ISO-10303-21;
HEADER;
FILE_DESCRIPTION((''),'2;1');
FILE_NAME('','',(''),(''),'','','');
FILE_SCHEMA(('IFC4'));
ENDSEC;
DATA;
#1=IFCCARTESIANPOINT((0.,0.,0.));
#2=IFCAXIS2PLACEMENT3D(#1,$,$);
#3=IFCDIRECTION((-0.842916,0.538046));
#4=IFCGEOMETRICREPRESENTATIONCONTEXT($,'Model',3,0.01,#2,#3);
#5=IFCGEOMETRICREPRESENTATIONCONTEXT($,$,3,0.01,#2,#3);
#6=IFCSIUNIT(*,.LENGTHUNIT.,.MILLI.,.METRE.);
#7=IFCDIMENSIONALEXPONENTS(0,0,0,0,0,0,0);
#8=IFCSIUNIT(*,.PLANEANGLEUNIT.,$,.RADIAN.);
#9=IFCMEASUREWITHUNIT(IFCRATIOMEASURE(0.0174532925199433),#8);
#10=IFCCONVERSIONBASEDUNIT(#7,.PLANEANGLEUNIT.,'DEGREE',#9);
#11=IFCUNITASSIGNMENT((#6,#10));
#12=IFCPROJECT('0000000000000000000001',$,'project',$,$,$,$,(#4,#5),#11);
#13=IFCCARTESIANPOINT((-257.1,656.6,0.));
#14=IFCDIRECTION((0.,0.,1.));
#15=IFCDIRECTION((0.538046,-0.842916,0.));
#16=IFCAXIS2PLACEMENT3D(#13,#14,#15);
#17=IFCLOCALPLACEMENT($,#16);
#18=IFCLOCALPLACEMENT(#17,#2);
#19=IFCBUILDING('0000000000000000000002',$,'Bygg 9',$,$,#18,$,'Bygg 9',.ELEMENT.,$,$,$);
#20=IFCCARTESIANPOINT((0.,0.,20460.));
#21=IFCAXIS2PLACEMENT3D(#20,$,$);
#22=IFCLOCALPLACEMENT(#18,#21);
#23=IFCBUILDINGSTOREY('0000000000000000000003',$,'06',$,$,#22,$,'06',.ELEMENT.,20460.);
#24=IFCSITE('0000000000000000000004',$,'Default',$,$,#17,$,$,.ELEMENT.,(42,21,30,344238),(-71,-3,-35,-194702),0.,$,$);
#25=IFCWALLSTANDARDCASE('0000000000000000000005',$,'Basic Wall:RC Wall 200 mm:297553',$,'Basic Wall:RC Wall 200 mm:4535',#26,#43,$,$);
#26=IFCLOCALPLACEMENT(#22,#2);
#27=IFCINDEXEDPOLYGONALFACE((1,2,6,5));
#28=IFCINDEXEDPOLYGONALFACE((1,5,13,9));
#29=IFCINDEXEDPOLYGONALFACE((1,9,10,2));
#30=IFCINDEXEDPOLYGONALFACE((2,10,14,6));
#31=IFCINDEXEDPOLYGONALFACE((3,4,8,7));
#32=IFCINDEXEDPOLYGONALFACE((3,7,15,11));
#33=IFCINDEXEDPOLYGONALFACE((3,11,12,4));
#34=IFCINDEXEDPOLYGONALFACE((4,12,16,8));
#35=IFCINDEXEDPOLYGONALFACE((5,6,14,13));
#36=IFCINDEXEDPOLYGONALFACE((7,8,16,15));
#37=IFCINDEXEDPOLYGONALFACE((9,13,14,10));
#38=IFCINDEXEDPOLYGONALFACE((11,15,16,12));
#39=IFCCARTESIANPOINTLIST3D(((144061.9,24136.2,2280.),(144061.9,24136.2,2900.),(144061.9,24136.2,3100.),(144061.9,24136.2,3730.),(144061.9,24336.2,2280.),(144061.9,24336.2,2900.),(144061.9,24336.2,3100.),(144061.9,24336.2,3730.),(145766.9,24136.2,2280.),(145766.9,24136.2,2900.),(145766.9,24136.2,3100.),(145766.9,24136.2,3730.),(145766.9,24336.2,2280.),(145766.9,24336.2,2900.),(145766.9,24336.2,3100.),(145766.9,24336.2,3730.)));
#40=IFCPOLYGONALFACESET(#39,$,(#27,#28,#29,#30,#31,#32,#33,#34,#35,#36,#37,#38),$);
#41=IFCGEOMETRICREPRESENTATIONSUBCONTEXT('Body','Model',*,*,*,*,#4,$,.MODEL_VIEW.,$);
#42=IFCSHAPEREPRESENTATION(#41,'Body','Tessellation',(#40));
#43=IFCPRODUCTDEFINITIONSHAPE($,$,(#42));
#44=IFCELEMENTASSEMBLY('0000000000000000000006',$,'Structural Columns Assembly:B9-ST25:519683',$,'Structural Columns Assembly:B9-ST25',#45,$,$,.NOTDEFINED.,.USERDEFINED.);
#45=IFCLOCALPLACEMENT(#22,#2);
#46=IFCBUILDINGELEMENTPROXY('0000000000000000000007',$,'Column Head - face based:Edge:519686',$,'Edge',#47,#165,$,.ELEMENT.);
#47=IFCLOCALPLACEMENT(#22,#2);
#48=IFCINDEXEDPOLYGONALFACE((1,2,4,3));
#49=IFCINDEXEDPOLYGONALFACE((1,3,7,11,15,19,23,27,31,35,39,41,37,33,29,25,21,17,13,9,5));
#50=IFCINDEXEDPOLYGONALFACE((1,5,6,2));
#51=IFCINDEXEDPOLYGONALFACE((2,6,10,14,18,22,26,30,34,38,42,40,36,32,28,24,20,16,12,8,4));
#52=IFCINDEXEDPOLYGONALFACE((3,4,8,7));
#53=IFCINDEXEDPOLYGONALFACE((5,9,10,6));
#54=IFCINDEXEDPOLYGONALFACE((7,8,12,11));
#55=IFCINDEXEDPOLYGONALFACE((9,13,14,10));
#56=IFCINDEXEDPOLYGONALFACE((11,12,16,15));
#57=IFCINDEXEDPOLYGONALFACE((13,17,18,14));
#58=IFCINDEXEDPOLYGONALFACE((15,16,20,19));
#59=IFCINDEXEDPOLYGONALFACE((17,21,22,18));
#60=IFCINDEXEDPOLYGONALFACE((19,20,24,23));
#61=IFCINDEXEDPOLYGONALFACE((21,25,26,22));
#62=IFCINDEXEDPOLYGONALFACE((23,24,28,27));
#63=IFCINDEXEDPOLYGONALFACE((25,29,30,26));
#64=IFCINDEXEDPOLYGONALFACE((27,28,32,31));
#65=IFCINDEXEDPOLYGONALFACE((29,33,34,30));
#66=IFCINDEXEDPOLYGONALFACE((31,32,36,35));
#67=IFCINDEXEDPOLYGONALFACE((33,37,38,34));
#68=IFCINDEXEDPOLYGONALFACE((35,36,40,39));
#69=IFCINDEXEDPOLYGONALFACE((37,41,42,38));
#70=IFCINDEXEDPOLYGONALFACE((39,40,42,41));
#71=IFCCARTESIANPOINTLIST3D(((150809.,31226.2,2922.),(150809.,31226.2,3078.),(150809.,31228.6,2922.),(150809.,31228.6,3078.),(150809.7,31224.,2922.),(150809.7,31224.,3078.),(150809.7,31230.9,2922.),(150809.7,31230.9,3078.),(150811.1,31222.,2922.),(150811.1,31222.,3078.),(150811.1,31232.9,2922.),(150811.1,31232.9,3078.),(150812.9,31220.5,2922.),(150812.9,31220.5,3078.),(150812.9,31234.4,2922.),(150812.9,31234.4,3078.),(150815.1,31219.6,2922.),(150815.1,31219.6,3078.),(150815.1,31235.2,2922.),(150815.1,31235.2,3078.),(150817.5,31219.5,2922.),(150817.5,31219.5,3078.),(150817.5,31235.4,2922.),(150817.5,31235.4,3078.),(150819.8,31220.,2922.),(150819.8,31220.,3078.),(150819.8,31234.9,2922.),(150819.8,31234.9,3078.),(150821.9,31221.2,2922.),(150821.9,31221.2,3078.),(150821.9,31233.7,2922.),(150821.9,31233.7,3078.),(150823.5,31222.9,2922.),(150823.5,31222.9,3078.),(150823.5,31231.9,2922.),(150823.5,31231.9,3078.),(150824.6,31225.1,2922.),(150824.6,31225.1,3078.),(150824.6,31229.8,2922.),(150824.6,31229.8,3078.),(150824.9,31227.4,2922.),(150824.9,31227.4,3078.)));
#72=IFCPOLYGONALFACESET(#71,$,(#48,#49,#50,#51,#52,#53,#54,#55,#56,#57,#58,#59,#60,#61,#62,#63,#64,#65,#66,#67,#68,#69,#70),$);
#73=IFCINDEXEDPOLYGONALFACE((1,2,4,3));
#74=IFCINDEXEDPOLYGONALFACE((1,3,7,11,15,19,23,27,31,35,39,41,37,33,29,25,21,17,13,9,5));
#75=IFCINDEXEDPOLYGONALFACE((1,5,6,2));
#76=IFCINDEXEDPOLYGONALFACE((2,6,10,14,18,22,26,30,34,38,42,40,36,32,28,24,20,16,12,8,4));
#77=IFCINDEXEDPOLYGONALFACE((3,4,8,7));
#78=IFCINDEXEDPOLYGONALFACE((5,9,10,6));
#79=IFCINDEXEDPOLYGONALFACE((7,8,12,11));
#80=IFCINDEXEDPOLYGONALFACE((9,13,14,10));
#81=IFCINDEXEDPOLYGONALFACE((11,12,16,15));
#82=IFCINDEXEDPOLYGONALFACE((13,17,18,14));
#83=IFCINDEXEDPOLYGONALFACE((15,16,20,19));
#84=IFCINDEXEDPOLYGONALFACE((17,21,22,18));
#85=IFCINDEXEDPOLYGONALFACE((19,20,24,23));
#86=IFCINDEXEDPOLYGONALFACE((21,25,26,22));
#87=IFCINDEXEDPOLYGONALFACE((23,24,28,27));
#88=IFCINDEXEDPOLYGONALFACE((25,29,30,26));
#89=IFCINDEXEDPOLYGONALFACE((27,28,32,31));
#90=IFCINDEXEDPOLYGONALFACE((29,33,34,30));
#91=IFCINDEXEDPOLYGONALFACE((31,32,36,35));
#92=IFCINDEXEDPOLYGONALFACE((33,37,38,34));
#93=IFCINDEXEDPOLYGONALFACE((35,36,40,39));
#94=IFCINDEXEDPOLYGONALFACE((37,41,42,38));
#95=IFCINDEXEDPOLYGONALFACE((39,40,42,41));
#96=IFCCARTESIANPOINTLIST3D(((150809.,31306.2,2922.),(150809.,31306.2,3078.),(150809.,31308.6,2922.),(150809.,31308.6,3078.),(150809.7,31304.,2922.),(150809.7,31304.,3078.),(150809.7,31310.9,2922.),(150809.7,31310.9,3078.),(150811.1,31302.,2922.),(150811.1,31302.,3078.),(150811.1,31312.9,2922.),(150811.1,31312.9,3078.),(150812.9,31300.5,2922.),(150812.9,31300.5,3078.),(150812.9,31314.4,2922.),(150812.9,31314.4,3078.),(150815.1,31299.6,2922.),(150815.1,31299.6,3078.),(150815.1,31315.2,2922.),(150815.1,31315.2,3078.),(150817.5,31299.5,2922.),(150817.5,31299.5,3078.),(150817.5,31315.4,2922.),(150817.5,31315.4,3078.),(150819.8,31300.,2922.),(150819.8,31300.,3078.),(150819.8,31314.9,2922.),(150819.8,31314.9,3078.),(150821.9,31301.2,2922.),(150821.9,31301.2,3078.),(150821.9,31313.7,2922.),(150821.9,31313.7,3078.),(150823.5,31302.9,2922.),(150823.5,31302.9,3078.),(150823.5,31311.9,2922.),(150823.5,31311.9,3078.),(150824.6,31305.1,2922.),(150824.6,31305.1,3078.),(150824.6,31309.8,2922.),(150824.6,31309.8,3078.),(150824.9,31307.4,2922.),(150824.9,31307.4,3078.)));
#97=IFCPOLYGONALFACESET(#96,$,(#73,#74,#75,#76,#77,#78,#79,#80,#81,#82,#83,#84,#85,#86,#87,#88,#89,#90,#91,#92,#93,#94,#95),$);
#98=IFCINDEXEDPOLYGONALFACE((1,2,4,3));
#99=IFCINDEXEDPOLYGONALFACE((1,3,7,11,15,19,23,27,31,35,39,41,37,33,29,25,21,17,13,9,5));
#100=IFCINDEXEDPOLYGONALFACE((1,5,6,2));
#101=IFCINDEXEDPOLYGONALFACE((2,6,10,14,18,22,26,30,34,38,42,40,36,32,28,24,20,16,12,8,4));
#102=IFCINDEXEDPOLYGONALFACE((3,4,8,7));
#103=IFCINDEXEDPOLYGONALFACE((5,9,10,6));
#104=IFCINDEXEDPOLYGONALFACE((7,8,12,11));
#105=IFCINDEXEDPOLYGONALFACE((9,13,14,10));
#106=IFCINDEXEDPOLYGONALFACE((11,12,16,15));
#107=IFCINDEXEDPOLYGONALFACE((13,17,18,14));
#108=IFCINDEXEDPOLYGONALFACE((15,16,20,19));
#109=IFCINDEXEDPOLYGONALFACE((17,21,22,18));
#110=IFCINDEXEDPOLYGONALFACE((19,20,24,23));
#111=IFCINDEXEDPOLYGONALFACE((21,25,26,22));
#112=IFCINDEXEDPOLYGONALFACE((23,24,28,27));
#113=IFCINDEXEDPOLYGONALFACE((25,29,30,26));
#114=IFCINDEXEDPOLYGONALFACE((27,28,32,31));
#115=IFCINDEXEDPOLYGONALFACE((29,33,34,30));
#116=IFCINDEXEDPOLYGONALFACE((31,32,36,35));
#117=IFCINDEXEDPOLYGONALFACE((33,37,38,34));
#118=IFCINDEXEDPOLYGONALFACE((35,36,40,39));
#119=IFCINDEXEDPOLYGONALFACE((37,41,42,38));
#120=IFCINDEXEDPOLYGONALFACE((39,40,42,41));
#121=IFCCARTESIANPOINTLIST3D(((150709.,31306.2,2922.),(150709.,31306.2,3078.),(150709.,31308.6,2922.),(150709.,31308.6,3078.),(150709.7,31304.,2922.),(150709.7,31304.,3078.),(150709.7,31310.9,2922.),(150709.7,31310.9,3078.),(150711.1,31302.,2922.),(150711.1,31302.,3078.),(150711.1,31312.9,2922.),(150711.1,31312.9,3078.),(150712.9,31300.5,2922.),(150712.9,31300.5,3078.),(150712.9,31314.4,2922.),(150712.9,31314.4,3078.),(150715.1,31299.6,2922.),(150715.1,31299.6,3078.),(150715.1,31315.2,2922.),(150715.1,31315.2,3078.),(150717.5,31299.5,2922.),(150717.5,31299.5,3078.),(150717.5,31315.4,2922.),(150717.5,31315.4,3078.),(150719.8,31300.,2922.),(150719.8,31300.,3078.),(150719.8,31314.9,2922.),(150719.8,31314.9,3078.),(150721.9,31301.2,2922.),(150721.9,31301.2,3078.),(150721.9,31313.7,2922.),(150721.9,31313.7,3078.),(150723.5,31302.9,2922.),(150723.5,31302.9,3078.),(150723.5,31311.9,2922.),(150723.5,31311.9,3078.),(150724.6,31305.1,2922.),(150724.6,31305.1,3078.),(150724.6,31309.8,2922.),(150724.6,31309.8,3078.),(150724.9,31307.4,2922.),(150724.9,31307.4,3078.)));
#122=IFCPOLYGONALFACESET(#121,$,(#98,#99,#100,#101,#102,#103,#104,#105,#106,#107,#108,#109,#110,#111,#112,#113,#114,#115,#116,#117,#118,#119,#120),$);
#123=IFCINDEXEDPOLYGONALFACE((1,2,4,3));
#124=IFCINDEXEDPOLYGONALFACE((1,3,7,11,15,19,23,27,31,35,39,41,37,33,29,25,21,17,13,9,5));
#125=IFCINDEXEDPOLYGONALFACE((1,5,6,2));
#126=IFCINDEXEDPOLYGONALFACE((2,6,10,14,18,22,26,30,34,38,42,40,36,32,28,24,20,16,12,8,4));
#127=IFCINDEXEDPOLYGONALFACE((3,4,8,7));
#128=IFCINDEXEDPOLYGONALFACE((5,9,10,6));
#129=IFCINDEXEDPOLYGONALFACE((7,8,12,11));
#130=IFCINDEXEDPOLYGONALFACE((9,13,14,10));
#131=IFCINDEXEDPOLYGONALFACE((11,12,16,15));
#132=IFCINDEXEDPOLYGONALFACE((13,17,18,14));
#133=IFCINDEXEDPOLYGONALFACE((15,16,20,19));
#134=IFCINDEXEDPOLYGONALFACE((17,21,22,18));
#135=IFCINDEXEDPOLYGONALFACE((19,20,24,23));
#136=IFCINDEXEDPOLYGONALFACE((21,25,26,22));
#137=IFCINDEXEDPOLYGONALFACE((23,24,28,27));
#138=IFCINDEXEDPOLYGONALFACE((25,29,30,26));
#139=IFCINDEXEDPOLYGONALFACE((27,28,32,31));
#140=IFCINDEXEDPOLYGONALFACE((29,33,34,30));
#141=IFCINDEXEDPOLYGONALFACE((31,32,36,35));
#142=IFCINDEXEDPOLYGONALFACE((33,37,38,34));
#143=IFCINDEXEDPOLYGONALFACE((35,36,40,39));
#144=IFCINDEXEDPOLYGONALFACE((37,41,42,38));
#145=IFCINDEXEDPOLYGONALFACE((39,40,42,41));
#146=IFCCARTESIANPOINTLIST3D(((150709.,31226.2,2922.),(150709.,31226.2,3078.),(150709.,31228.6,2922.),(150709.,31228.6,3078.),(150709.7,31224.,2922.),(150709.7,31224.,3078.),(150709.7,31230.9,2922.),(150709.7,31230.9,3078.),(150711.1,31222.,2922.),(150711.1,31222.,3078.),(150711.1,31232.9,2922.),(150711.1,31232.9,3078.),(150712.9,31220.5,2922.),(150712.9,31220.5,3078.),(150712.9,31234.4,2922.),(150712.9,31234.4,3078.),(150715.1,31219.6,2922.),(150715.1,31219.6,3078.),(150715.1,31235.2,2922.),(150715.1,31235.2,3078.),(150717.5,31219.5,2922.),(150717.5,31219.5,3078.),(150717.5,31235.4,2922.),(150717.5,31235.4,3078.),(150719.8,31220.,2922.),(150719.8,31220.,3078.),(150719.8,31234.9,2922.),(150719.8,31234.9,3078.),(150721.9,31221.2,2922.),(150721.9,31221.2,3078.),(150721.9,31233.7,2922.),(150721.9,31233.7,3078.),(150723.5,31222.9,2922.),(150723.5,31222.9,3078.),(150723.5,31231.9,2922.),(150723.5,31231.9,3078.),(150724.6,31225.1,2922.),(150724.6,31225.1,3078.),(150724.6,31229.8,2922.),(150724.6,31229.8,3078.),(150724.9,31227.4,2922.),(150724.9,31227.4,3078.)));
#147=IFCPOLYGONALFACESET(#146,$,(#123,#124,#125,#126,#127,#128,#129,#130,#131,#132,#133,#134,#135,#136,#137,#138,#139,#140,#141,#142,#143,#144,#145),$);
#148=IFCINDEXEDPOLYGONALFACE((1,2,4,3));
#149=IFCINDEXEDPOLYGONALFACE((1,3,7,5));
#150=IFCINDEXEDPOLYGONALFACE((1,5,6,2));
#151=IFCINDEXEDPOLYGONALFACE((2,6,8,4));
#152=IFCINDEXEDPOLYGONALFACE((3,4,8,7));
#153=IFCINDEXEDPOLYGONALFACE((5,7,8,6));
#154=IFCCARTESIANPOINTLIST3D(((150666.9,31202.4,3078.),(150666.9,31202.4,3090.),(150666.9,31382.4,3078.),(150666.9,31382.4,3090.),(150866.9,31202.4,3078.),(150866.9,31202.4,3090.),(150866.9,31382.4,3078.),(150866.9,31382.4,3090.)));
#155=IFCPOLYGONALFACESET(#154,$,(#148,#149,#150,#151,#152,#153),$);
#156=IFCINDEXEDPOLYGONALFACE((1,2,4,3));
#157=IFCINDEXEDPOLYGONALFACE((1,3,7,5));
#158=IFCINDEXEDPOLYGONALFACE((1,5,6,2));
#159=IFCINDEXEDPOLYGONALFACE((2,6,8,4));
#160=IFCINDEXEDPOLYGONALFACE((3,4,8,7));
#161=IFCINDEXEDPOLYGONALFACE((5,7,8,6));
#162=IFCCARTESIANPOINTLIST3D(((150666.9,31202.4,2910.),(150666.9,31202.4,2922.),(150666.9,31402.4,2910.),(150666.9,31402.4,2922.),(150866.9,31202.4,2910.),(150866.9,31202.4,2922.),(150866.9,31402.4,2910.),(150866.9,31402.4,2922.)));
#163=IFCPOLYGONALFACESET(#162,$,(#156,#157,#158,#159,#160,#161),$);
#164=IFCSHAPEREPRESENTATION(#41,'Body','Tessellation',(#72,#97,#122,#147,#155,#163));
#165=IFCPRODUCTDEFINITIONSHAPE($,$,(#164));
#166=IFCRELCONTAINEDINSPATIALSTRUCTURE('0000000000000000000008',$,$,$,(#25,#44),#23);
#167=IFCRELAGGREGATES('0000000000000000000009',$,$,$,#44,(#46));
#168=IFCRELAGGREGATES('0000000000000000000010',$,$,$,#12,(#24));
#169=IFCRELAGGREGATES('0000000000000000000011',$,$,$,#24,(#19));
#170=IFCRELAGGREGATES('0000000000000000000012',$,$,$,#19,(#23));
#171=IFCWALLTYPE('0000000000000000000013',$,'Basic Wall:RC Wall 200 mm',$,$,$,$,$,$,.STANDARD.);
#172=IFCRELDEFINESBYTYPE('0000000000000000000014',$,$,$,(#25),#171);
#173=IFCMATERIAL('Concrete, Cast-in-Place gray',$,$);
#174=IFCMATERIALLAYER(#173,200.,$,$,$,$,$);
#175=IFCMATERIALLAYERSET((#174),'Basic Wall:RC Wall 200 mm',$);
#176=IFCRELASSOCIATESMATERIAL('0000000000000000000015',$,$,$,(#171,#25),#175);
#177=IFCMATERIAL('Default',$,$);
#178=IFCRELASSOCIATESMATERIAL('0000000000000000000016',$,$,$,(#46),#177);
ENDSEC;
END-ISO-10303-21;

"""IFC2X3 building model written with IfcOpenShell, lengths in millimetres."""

from ifc_helpers import new_model, entity, si_unit, converted_unit, direction, frame, frame_2d, origin, origin_2d_with_axis, place, context, subcontext, project, spatial, polyline, rectangle, circle, extrude, clip, bounded_halfspace, source, transform, mapped, material, layer, layer_set, layer_usage, type_object, element, aggregate, save


model = new_model("IFC2X3")

# Units and contexts
model_context = context("Model", 3, precision=0.01, world=origin(), true_north=direction((-0.842916, 0.538046)))
context_of_model = context(None, 3, precision=0.01, world=origin(), true_north=direction((-0.842916, 0.538046)))
body_context = subcontext(model_context, "Body", "Model", "MODEL_VIEW")
ifc_project = project(units=[si_unit("LENGTHUNIT", "METRE", prefix="MILLI"), converted_unit("PLANEANGLEUNIT", "DEGREE", entity("IfcRatioMeasure", 0.0174532925199433), si_unit("PLANEANGLEUNIT", "RADIAN"), dimensions=[0, 0, 0, 0, 0, 0, 0])], contexts=[model_context, context_of_model])

# Site, building, storey
site_placement = place(None, frame((-257.1, 656.6, 0.0), z_axis=(0.0, 0.0, 1.0), x_axis=(0.538046, -0.842916, 0.0)))
site = spatial("IfcSite", under=ifc_project, at=site_placement, Name="Default", CompositionType="ELEMENT", RefLatitude=(42, 21, 30, 344238), RefLongitude=(-71, -3, -35, -194702), RefElevation=0.0)
building_placement = place(site_placement, origin())
building = spatial("IfcBuilding", under=site, at=building_placement, Name="Bygg 9", LongName="Bygg 9", CompositionType="ELEMENT")
storey_placement = place(building_placement, frame((0.0, 0.0, 20460.0)))
storey = spatial("IfcBuildingStorey", under=building, at=storey_placement, Name="06", LongName="06", CompositionType="ELEMENT", Elevation=20460.0)

# Shared definitions
ifc_material_1 = material(Name="Concrete, Cast-in-Place gray")

# Shared definitions
ifc_layer_1 = layer(ifc_material_1, 200.0)
ifc_layer_set_1 = layer_set([ifc_layer_1], Name="Basic Wall:RC Wall 200 mm")
wall_type = type_object("IfcWallType", Name="Basic Wall:RC Wall 200 mm", PredefinedType="STANDARD", material=ifc_layer_set_1)

# Wall, opening
ifc_layer_usage_1 = layer_usage(ifc_layer_set_1, "AXIS2", "NEGATIVE", 100.0)
wall_1_placement = place(storey_placement, frame((145766.9, 24236.2, 2280.0), z_axis=(0.0, 0.0, 1.0), x_axis=(-1.0, 0.0, 0.0)))
wall_1 = element("IfcWallStandardCase", 1, at=wall_1_placement, inside=storey, type_object=wall_type, material=ifc_layer_usage_1, Name="Basic Wall:RC Wall 200 mm:297553", ObjectType="Basic Wall:RC Wall 200 mm:4535", context=body_context, shape_type="Clipping", body=[
    clip(extrude(rectangle(XDim=1705.0, YDim=200.0, at=frame_2d((852.5, 0.0), x_axis=(-1.0, 0.0))), origin(), (0.0, 0.0, 1.0), 1450.0), bounded_halfspace(frame((0.0, -100.0, 1450.0), z_axis=(0.0, 0.0, -1.0), x_axis=(0.0, 1.0, 0.0)), True, frame((0.0, -100.0, 1450.0)), polyline([(0.0, 0.0), (1705.0, 0.0), (1705.0, 200.0), (978.6, 200.0), (825.7, 200.0), (0.0, 200.0), (0.0, 0.0)]))),
])
opening_placement = place(storey_placement, frame((145766.9, 24236.2, 2280.0), z_axis=(0.0, 0.0, 1.0), x_axis=(-1.0, 0.0, 0.0)))
element("IfcOpeningElement", 2, at=opening_placement, cuts=wall_1, ObjectType="Opening", context=body_context, shape_type="SweptSolid", body=[
    extrude(rectangle(XDim=1705.0, YDim=200.0, at=frame_2d((0.0, 0.0), x_axis=(1.0, 0.0))), frame((852.5, 0.0, 620.0)), (0.0, 0.0, 1.0), 200.0),
])

# Element assembly, building element proxy
assembly_1_placement = place(storey_placement, origin())
assembly_1 = element("IfcElementAssembly", 3, at=assembly_1_placement, inside=storey, Name="Structural Columns Assembly:B9-ST25:519683", ObjectType="Structural Columns Assembly:B9-ST25", AssemblyPlace="NOTDEFINED", PredefinedType="USERDEFINED")
ifc_material_2 = material(Name="Default")
shared_shape_1 = source(origin(), body_context, "Body", "SweptSolid", [
    extrude(circle(Radius=8.0, at=frame_2d((0.0, 0.0), x_axis=(1.0, 0.0))), frame((50.0, -135.0, 12.0)), (0.0, 0.0, 1.0), 156.0),
    extrude(circle(Radius=8.0, at=frame_2d((0.0, 0.0), x_axis=(1.0, 0.0))), frame((50.0, -55.0, 12.0)), (0.0, 0.0, 1.0), 156.0),
    extrude(circle(Radius=8.0, at=frame_2d((0.0, 0.0), x_axis=(1.0, 0.0))), frame((-50.0, -55.0, 12.0)), (0.0, 0.0, 1.0), 156.0),
    extrude(circle(Radius=8.0, at=frame_2d((0.0, 0.0), x_axis=(1.0, 0.0))), frame((-50.0, -135.0, 12.0)), (0.0, 0.0, 1.0), 156.0),
    extrude(rectangle(XDim=200.0, YDim=180.0, at=origin_2d_with_axis()), frame((0.0, -70.0, 168.0), z_axis=(0.0, 0.0, 1.0), x_axis=(-1.0, 0.0, 0.0)), (0.0, 0.0, 1.0), 12.0),
    extrude(rectangle(XDim=200.0, YDim=200.0, at=origin_2d_with_axis()), frame((0.0, -60.0, 0.0), z_axis=(0.0, 0.0, 1.0), x_axis=(0.0, 1.0, 0.0)), (0.0, 0.0, 1.0), 12.0),
])
proxy_1_placement = place(assembly_1_placement, frame((150766.9, 31362.4, 2910.0)))
proxy_1 = element("IfcBuildingElementProxy", 4, at=proxy_1_placement, material=ifc_material_2, Name="Column Head - face based:Edge:519686", ObjectType="Edge", CompositionType="ELEMENT", context=body_context, shape_type="MappedRepresentation", body=[
    mapped(shared_shape_1, transform((0.0, 0.0, 0.0), scale=1.0)),
])
aggregate(assembly_1, [proxy_1])

save(model, "model.ifc")
